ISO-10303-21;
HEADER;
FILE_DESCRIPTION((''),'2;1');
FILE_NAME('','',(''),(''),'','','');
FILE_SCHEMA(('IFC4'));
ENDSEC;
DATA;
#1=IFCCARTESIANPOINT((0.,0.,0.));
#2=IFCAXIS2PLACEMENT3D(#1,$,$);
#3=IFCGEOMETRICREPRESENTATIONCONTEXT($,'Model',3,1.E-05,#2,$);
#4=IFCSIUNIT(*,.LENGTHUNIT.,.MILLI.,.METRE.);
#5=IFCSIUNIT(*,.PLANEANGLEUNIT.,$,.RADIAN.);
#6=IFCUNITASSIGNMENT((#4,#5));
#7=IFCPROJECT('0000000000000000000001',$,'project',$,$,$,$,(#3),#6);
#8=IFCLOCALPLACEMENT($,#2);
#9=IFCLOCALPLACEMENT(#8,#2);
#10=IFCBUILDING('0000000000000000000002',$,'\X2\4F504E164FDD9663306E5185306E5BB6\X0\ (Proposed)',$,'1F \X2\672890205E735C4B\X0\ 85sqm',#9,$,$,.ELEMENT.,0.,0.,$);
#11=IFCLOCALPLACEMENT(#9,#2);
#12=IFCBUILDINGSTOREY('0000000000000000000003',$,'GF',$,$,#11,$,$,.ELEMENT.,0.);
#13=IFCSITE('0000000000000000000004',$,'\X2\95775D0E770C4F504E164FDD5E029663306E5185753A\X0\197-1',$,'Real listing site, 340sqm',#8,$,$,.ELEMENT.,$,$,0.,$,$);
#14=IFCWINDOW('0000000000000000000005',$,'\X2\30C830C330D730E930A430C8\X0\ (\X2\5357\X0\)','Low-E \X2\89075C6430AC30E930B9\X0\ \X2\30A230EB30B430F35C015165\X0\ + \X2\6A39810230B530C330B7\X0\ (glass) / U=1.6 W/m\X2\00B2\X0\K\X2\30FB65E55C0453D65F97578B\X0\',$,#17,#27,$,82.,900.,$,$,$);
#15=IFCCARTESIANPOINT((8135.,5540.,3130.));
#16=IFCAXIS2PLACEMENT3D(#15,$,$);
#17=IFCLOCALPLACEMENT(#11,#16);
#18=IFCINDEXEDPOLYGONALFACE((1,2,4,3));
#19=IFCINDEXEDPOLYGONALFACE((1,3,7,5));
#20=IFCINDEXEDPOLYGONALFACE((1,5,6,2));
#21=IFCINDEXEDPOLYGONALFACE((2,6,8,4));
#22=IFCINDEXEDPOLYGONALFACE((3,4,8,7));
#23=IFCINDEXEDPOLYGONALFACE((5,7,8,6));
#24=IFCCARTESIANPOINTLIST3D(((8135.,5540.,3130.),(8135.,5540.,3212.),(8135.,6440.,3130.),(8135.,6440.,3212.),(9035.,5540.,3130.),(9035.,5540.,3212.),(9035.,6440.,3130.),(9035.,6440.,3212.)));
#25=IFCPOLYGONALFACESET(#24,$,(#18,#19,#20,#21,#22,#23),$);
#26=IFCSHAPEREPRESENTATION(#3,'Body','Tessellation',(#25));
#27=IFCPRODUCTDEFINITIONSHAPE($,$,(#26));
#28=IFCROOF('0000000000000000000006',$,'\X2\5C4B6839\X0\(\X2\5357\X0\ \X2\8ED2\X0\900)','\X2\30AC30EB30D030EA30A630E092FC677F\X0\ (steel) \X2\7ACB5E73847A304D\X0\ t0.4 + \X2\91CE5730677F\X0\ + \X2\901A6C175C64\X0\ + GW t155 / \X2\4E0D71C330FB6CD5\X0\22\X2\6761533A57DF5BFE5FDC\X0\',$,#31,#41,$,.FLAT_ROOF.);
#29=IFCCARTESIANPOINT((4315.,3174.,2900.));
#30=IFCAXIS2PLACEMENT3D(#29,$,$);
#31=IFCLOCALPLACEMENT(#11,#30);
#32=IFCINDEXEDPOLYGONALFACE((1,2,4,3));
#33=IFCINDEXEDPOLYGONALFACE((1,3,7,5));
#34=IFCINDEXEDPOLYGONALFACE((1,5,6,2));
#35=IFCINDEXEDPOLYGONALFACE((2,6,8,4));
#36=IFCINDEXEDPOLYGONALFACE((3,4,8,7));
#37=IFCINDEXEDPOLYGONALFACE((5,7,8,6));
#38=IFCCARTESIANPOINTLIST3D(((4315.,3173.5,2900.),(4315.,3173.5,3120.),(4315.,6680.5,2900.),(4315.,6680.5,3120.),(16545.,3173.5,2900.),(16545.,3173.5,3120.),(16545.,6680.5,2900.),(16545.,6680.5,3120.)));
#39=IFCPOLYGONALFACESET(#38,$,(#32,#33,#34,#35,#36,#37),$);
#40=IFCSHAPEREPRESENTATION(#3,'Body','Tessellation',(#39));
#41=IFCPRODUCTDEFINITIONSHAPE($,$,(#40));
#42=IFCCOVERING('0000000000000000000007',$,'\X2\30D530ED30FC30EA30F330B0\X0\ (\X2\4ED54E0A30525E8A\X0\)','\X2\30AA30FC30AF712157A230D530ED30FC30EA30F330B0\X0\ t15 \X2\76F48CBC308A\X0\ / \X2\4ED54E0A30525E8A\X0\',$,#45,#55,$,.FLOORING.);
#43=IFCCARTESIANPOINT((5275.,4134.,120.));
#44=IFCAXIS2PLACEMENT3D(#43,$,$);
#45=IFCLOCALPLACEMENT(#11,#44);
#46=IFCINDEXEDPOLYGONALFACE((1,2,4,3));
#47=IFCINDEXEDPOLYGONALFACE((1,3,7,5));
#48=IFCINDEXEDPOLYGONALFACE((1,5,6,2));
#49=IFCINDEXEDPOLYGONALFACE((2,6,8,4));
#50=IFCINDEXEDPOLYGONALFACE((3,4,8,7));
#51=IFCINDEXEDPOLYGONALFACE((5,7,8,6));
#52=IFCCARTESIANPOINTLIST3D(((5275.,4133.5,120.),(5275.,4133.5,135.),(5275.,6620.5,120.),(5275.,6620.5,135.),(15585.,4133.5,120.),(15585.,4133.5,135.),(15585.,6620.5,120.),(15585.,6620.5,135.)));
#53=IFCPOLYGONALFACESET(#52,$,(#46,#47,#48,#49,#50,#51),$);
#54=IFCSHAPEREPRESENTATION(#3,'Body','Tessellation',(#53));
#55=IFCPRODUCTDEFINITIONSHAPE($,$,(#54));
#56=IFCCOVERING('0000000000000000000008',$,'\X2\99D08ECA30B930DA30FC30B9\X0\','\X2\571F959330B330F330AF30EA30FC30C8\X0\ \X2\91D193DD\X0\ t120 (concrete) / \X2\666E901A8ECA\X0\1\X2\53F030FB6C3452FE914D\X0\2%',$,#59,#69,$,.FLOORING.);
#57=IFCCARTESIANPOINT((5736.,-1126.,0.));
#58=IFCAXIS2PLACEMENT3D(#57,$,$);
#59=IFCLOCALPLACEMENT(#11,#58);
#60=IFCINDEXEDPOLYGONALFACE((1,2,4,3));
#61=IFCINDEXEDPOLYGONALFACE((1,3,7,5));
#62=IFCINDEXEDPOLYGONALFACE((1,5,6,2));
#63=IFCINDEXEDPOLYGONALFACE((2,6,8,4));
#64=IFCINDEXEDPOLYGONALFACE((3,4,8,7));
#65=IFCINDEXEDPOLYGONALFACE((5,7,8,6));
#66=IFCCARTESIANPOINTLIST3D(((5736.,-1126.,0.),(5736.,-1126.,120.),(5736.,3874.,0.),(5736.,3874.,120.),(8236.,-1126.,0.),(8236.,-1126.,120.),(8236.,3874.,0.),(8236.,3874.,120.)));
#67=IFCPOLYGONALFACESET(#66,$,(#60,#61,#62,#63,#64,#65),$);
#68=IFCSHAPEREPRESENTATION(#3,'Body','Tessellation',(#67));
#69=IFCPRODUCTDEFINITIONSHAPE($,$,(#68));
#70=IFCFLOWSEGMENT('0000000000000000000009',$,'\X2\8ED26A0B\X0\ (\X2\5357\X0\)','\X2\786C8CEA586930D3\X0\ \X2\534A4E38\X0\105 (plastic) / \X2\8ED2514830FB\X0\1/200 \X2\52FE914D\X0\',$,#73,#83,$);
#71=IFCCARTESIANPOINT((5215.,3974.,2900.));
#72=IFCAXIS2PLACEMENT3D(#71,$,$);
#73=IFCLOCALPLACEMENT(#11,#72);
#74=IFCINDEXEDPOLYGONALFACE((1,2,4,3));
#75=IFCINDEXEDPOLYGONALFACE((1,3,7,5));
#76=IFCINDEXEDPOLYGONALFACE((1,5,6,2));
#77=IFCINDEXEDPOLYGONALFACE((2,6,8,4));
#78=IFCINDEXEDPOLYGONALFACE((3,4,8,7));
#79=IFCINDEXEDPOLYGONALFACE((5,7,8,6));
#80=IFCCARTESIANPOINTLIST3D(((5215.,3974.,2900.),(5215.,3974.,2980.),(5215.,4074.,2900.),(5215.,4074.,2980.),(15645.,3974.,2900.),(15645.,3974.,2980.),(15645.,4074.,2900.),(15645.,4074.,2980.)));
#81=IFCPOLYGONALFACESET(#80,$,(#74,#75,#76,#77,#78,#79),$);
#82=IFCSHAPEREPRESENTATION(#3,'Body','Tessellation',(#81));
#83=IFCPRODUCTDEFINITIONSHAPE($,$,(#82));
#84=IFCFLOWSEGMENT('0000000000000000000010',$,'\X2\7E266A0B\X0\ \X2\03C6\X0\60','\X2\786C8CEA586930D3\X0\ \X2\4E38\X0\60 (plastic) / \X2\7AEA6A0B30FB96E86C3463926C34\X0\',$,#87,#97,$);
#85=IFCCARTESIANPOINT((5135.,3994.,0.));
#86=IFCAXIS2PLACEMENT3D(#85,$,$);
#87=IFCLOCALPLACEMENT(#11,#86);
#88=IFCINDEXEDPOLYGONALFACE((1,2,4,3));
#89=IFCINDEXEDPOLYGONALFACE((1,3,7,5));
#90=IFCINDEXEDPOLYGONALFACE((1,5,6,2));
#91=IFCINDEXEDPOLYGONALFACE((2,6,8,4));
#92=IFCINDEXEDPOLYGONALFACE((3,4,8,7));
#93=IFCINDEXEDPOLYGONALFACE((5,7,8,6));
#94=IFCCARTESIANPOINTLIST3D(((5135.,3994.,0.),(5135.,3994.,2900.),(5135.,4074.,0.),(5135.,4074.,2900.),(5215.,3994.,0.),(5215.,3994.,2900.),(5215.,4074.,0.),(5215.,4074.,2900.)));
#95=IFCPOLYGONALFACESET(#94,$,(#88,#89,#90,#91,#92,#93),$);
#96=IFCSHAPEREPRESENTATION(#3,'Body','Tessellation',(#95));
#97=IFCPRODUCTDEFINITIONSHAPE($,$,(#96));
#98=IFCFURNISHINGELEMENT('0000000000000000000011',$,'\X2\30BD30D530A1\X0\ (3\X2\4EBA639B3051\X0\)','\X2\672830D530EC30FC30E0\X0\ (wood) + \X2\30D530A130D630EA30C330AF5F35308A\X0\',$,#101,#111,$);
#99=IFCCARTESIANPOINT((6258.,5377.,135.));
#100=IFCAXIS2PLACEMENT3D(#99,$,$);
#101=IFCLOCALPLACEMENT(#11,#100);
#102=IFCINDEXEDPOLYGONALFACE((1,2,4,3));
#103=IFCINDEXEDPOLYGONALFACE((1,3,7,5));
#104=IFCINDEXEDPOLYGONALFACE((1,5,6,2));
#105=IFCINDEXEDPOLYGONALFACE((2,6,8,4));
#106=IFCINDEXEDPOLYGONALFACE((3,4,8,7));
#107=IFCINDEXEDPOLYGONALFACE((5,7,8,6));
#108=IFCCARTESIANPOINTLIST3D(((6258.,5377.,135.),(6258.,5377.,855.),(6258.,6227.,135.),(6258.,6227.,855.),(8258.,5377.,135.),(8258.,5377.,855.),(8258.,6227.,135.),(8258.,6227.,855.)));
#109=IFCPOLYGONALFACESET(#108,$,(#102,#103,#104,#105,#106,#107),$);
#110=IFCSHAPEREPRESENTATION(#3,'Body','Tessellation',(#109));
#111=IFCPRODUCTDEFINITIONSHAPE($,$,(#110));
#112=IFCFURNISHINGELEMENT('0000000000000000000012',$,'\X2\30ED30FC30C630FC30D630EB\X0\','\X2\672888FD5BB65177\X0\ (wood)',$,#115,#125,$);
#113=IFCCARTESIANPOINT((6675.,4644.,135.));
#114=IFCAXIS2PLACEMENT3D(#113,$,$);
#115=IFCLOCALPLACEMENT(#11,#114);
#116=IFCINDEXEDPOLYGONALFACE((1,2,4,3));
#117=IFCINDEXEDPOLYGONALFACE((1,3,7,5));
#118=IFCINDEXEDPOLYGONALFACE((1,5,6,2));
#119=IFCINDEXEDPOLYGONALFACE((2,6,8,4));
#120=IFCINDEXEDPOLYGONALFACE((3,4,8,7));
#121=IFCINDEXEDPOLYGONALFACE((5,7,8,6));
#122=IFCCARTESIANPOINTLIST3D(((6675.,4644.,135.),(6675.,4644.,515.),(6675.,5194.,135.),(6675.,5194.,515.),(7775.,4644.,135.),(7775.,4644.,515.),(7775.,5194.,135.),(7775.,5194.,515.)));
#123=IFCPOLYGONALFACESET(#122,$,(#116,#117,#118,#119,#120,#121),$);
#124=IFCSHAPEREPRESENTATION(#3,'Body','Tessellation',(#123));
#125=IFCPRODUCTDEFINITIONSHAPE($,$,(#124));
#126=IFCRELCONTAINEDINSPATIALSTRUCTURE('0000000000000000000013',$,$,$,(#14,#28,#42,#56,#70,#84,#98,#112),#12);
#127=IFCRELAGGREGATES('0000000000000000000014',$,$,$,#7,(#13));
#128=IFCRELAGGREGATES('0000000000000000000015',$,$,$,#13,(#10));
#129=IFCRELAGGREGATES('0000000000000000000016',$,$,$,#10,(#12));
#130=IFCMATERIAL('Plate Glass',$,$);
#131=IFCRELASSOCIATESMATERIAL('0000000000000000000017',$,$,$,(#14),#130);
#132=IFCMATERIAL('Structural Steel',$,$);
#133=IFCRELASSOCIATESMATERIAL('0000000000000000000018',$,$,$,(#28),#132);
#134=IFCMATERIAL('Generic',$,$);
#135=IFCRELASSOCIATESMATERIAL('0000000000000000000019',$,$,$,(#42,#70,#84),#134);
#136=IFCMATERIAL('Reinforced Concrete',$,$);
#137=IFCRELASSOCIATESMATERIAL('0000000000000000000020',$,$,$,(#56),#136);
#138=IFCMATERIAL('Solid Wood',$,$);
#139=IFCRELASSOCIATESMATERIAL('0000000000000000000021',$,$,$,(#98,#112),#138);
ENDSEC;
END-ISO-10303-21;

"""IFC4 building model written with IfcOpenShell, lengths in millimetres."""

from ifc_helpers import new_model, si_unit, frame, frame_2d, origin, place, context, project, spatial, rectangle, extrude, material, element, save


model = new_model("IFC4")

# Units and contexts
model_context = context("Model", 3, precision=1e-05, world=origin())
ifc_project = project(units=[si_unit("LENGTHUNIT", "METRE", prefix="MILLI"), si_unit("PLANEANGLEUNIT", "RADIAN")], contexts=[model_context])

# Site, building, storey
site_placement = place(None, origin())
site = spatial("IfcSite", under=ifc_project, at=site_placement, Name="長崎県佐世保市陣の内町197-1", ObjectType="Real listing site, 340sqm", CompositionType="ELEMENT", RefElevation=0.0)
building_placement = place(site_placement, origin())
building = spatial("IfcBuilding", under=site, at=building_placement, Name="佐世保陣の内の家 (Proposed)", ObjectType="1F 木造平屋 85sqm", CompositionType="ELEMENT", ElevationOfRefHeight=0.0, ElevationOfTerrain=0.0)
storey_placement = place(building_placement, origin())
storey = spatial("IfcBuildingStorey", under=building, at=storey_placement, Name="GF", CompositionType="ELEMENT", Elevation=0.0)

# Shared definitions
ifc_material_1 = material(Name="Solid Wood")

# Shared definitions
ifc_material_2 = material(Name="Reinforced Concrete")

# Shared definitions
ifc_material_3 = material(Name="Plate Glass")

# Window
window_1_placement = place(storey_placement, frame((8135.0, 5540.0, 3130.0)))
element("IfcWindow", 1, at=window_1_placement, inside=storey, material=ifc_material_3, Name="トップライト (南)", Description="Low-E 複層ガラス アルゴン封入 + 樹脂サッシ (glass) / U=1.6 W/m²K・日射取得型", OverallHeight=82.0, OverallWidth=900.0, context=model_context, shape_type="SweptSolid", body=[
    extrude(rectangle(XDim=900.0, YDim=900.0, at=frame_2d((450.0, 450.0))), frame((8135.0, 5540.0, 3130.0)), (0.0, 0.0, 1.0), 82.0),
])

# Roof
ifc_material_4 = material(Name="Structural Steel")
roof_1_placement = place(storey_placement, frame((4315.0, 3174.0, 2900.0)))
element("IfcRoof", 2, at=roof_1_placement, inside=storey, material=ifc_material_4, Name="屋根(南 軒900)", Description="ガルバリウム鋼板 (steel) 立平葺き t0.4 + 野地板 + 通気層 + GW t155 / 不燃・法22条区域対応", PredefinedType="FLAT_ROOF", context=model_context, shape_type="SweptSolid", body=[
    extrude(rectangle(XDim=12230.0, YDim=3507.0, at=frame_2d((6115.0, 1753.0))), frame((4315.0, 3174.0, 2900.0)), (0.0, 0.0, 1.0), 220.0),
])

# Coverings
ifc_material_5 = material(Name="Generic")
covering_1_placement = place(storey_placement, frame((5275.0, 4134.0, 120.0)))
element("IfcCovering", 3, at=covering_1_placement, inside=storey, material=ifc_material_5, Name="フローリング (仕上げ床)", Description="オーク無垢フローリング t15 直貼り / 仕上げ床", PredefinedType="FLOORING", context=model_context, shape_type="SweptSolid", body=[
    extrude(rectangle(XDim=10310.0, YDim=2487.0, at=frame_2d((5155.0, 1243.0))), frame((5275.0, 4134.0, 120.0)), (0.0, 0.0, 1.0), 15.0),
])
covering_2_placement = place(storey_placement, frame((5736.0, -1126.0, 0.0)))
element("IfcCovering", 4, at=covering_2_placement, inside=storey, material=ifc_material_2, Name="駐車スペース", Description="土間コンクリート 金鏝 t120 (concrete) / 普通車1台・水勾配2%", PredefinedType="FLOORING", context=model_context, shape_type="SweptSolid", body=[
    extrude(rectangle(XDim=2500.0, YDim=5000.0, at=frame_2d((1250.0, 2500.0))), frame((5736.0, -1126.0, 0.0)), (0.0, 0.0, 1.0), 120.0),
])

# Flow segments
flow_segment_1_placement = place(storey_placement, frame((5215.0, 3974.0, 2900.0)))
element("IfcFlowSegment", 5, at=flow_segment_1_placement, inside=storey, material=ifc_material_5, Name="軒樋 (南)", Description="硬質塩ビ 半丸105 (plastic) / 軒先・1/200 勾配", context=model_context, shape_type="SweptSolid", body=[
    extrude(rectangle(XDim=10430.0, YDim=100.0, at=frame_2d((5215.0, 50.0))), frame((5215.0, 3974.0, 2900.0)), (0.0, 0.0, 1.0), 80.0),
])
flow_segment_2_placement = place(storey_placement, frame((5135.0, 3994.0, 0.0)))
element("IfcFlowSegment", 6, at=flow_segment_2_placement, inside=storey, material=ifc_material_5, Name="縦樋 φ60", Description="硬質塩ビ 丸60 (plastic) / 竪樋・雨水排水", context=model_context, shape_type="SweptSolid", body=[
    extrude(rectangle(XDim=80.0, YDim=80.0, at=frame_2d((40.0, 40.0))), frame((5135.0, 3994.0, 0.0)), (0.0, 0.0, 1.0), 2900.0),
])

# Furnishing elements
furnishing_1_placement = place(storey_placement, frame((6258.0, 5377.0, 135.0)))
element("IfcFurnishingElement", 7, at=furnishing_1_placement, inside=storey, material=ifc_material_1, Name="ソファ (3人掛け)", Description="木フレーム (wood) + ファブリック張り", context=model_context, shape_type="SweptSolid", body=[
    extrude(rectangle(XDim=2000.0, YDim=850.0, at=frame_2d((1000.0, 425.0))), frame((6258.0, 5377.0, 135.0)), (0.0, 0.0, 1.0), 720.0),
])
furnishing_2_placement = place(storey_placement, frame((6675.0, 4644.0, 135.0)))
element("IfcFurnishingElement", 8, at=furnishing_2_placement, inside=storey, material=ifc_material_1, Name="ローテーブル", Description="木製家具 (wood)", context=model_context, shape_type="SweptSolid", body=[
    extrude(rectangle(XDim=1100.0, YDim=550.0, at=frame_2d((550.0, 275.0))), frame((6675.0, 4644.0, 135.0)), (0.0, 0.0, 1.0), 380.0),
])

save(model, "model.ifc")
